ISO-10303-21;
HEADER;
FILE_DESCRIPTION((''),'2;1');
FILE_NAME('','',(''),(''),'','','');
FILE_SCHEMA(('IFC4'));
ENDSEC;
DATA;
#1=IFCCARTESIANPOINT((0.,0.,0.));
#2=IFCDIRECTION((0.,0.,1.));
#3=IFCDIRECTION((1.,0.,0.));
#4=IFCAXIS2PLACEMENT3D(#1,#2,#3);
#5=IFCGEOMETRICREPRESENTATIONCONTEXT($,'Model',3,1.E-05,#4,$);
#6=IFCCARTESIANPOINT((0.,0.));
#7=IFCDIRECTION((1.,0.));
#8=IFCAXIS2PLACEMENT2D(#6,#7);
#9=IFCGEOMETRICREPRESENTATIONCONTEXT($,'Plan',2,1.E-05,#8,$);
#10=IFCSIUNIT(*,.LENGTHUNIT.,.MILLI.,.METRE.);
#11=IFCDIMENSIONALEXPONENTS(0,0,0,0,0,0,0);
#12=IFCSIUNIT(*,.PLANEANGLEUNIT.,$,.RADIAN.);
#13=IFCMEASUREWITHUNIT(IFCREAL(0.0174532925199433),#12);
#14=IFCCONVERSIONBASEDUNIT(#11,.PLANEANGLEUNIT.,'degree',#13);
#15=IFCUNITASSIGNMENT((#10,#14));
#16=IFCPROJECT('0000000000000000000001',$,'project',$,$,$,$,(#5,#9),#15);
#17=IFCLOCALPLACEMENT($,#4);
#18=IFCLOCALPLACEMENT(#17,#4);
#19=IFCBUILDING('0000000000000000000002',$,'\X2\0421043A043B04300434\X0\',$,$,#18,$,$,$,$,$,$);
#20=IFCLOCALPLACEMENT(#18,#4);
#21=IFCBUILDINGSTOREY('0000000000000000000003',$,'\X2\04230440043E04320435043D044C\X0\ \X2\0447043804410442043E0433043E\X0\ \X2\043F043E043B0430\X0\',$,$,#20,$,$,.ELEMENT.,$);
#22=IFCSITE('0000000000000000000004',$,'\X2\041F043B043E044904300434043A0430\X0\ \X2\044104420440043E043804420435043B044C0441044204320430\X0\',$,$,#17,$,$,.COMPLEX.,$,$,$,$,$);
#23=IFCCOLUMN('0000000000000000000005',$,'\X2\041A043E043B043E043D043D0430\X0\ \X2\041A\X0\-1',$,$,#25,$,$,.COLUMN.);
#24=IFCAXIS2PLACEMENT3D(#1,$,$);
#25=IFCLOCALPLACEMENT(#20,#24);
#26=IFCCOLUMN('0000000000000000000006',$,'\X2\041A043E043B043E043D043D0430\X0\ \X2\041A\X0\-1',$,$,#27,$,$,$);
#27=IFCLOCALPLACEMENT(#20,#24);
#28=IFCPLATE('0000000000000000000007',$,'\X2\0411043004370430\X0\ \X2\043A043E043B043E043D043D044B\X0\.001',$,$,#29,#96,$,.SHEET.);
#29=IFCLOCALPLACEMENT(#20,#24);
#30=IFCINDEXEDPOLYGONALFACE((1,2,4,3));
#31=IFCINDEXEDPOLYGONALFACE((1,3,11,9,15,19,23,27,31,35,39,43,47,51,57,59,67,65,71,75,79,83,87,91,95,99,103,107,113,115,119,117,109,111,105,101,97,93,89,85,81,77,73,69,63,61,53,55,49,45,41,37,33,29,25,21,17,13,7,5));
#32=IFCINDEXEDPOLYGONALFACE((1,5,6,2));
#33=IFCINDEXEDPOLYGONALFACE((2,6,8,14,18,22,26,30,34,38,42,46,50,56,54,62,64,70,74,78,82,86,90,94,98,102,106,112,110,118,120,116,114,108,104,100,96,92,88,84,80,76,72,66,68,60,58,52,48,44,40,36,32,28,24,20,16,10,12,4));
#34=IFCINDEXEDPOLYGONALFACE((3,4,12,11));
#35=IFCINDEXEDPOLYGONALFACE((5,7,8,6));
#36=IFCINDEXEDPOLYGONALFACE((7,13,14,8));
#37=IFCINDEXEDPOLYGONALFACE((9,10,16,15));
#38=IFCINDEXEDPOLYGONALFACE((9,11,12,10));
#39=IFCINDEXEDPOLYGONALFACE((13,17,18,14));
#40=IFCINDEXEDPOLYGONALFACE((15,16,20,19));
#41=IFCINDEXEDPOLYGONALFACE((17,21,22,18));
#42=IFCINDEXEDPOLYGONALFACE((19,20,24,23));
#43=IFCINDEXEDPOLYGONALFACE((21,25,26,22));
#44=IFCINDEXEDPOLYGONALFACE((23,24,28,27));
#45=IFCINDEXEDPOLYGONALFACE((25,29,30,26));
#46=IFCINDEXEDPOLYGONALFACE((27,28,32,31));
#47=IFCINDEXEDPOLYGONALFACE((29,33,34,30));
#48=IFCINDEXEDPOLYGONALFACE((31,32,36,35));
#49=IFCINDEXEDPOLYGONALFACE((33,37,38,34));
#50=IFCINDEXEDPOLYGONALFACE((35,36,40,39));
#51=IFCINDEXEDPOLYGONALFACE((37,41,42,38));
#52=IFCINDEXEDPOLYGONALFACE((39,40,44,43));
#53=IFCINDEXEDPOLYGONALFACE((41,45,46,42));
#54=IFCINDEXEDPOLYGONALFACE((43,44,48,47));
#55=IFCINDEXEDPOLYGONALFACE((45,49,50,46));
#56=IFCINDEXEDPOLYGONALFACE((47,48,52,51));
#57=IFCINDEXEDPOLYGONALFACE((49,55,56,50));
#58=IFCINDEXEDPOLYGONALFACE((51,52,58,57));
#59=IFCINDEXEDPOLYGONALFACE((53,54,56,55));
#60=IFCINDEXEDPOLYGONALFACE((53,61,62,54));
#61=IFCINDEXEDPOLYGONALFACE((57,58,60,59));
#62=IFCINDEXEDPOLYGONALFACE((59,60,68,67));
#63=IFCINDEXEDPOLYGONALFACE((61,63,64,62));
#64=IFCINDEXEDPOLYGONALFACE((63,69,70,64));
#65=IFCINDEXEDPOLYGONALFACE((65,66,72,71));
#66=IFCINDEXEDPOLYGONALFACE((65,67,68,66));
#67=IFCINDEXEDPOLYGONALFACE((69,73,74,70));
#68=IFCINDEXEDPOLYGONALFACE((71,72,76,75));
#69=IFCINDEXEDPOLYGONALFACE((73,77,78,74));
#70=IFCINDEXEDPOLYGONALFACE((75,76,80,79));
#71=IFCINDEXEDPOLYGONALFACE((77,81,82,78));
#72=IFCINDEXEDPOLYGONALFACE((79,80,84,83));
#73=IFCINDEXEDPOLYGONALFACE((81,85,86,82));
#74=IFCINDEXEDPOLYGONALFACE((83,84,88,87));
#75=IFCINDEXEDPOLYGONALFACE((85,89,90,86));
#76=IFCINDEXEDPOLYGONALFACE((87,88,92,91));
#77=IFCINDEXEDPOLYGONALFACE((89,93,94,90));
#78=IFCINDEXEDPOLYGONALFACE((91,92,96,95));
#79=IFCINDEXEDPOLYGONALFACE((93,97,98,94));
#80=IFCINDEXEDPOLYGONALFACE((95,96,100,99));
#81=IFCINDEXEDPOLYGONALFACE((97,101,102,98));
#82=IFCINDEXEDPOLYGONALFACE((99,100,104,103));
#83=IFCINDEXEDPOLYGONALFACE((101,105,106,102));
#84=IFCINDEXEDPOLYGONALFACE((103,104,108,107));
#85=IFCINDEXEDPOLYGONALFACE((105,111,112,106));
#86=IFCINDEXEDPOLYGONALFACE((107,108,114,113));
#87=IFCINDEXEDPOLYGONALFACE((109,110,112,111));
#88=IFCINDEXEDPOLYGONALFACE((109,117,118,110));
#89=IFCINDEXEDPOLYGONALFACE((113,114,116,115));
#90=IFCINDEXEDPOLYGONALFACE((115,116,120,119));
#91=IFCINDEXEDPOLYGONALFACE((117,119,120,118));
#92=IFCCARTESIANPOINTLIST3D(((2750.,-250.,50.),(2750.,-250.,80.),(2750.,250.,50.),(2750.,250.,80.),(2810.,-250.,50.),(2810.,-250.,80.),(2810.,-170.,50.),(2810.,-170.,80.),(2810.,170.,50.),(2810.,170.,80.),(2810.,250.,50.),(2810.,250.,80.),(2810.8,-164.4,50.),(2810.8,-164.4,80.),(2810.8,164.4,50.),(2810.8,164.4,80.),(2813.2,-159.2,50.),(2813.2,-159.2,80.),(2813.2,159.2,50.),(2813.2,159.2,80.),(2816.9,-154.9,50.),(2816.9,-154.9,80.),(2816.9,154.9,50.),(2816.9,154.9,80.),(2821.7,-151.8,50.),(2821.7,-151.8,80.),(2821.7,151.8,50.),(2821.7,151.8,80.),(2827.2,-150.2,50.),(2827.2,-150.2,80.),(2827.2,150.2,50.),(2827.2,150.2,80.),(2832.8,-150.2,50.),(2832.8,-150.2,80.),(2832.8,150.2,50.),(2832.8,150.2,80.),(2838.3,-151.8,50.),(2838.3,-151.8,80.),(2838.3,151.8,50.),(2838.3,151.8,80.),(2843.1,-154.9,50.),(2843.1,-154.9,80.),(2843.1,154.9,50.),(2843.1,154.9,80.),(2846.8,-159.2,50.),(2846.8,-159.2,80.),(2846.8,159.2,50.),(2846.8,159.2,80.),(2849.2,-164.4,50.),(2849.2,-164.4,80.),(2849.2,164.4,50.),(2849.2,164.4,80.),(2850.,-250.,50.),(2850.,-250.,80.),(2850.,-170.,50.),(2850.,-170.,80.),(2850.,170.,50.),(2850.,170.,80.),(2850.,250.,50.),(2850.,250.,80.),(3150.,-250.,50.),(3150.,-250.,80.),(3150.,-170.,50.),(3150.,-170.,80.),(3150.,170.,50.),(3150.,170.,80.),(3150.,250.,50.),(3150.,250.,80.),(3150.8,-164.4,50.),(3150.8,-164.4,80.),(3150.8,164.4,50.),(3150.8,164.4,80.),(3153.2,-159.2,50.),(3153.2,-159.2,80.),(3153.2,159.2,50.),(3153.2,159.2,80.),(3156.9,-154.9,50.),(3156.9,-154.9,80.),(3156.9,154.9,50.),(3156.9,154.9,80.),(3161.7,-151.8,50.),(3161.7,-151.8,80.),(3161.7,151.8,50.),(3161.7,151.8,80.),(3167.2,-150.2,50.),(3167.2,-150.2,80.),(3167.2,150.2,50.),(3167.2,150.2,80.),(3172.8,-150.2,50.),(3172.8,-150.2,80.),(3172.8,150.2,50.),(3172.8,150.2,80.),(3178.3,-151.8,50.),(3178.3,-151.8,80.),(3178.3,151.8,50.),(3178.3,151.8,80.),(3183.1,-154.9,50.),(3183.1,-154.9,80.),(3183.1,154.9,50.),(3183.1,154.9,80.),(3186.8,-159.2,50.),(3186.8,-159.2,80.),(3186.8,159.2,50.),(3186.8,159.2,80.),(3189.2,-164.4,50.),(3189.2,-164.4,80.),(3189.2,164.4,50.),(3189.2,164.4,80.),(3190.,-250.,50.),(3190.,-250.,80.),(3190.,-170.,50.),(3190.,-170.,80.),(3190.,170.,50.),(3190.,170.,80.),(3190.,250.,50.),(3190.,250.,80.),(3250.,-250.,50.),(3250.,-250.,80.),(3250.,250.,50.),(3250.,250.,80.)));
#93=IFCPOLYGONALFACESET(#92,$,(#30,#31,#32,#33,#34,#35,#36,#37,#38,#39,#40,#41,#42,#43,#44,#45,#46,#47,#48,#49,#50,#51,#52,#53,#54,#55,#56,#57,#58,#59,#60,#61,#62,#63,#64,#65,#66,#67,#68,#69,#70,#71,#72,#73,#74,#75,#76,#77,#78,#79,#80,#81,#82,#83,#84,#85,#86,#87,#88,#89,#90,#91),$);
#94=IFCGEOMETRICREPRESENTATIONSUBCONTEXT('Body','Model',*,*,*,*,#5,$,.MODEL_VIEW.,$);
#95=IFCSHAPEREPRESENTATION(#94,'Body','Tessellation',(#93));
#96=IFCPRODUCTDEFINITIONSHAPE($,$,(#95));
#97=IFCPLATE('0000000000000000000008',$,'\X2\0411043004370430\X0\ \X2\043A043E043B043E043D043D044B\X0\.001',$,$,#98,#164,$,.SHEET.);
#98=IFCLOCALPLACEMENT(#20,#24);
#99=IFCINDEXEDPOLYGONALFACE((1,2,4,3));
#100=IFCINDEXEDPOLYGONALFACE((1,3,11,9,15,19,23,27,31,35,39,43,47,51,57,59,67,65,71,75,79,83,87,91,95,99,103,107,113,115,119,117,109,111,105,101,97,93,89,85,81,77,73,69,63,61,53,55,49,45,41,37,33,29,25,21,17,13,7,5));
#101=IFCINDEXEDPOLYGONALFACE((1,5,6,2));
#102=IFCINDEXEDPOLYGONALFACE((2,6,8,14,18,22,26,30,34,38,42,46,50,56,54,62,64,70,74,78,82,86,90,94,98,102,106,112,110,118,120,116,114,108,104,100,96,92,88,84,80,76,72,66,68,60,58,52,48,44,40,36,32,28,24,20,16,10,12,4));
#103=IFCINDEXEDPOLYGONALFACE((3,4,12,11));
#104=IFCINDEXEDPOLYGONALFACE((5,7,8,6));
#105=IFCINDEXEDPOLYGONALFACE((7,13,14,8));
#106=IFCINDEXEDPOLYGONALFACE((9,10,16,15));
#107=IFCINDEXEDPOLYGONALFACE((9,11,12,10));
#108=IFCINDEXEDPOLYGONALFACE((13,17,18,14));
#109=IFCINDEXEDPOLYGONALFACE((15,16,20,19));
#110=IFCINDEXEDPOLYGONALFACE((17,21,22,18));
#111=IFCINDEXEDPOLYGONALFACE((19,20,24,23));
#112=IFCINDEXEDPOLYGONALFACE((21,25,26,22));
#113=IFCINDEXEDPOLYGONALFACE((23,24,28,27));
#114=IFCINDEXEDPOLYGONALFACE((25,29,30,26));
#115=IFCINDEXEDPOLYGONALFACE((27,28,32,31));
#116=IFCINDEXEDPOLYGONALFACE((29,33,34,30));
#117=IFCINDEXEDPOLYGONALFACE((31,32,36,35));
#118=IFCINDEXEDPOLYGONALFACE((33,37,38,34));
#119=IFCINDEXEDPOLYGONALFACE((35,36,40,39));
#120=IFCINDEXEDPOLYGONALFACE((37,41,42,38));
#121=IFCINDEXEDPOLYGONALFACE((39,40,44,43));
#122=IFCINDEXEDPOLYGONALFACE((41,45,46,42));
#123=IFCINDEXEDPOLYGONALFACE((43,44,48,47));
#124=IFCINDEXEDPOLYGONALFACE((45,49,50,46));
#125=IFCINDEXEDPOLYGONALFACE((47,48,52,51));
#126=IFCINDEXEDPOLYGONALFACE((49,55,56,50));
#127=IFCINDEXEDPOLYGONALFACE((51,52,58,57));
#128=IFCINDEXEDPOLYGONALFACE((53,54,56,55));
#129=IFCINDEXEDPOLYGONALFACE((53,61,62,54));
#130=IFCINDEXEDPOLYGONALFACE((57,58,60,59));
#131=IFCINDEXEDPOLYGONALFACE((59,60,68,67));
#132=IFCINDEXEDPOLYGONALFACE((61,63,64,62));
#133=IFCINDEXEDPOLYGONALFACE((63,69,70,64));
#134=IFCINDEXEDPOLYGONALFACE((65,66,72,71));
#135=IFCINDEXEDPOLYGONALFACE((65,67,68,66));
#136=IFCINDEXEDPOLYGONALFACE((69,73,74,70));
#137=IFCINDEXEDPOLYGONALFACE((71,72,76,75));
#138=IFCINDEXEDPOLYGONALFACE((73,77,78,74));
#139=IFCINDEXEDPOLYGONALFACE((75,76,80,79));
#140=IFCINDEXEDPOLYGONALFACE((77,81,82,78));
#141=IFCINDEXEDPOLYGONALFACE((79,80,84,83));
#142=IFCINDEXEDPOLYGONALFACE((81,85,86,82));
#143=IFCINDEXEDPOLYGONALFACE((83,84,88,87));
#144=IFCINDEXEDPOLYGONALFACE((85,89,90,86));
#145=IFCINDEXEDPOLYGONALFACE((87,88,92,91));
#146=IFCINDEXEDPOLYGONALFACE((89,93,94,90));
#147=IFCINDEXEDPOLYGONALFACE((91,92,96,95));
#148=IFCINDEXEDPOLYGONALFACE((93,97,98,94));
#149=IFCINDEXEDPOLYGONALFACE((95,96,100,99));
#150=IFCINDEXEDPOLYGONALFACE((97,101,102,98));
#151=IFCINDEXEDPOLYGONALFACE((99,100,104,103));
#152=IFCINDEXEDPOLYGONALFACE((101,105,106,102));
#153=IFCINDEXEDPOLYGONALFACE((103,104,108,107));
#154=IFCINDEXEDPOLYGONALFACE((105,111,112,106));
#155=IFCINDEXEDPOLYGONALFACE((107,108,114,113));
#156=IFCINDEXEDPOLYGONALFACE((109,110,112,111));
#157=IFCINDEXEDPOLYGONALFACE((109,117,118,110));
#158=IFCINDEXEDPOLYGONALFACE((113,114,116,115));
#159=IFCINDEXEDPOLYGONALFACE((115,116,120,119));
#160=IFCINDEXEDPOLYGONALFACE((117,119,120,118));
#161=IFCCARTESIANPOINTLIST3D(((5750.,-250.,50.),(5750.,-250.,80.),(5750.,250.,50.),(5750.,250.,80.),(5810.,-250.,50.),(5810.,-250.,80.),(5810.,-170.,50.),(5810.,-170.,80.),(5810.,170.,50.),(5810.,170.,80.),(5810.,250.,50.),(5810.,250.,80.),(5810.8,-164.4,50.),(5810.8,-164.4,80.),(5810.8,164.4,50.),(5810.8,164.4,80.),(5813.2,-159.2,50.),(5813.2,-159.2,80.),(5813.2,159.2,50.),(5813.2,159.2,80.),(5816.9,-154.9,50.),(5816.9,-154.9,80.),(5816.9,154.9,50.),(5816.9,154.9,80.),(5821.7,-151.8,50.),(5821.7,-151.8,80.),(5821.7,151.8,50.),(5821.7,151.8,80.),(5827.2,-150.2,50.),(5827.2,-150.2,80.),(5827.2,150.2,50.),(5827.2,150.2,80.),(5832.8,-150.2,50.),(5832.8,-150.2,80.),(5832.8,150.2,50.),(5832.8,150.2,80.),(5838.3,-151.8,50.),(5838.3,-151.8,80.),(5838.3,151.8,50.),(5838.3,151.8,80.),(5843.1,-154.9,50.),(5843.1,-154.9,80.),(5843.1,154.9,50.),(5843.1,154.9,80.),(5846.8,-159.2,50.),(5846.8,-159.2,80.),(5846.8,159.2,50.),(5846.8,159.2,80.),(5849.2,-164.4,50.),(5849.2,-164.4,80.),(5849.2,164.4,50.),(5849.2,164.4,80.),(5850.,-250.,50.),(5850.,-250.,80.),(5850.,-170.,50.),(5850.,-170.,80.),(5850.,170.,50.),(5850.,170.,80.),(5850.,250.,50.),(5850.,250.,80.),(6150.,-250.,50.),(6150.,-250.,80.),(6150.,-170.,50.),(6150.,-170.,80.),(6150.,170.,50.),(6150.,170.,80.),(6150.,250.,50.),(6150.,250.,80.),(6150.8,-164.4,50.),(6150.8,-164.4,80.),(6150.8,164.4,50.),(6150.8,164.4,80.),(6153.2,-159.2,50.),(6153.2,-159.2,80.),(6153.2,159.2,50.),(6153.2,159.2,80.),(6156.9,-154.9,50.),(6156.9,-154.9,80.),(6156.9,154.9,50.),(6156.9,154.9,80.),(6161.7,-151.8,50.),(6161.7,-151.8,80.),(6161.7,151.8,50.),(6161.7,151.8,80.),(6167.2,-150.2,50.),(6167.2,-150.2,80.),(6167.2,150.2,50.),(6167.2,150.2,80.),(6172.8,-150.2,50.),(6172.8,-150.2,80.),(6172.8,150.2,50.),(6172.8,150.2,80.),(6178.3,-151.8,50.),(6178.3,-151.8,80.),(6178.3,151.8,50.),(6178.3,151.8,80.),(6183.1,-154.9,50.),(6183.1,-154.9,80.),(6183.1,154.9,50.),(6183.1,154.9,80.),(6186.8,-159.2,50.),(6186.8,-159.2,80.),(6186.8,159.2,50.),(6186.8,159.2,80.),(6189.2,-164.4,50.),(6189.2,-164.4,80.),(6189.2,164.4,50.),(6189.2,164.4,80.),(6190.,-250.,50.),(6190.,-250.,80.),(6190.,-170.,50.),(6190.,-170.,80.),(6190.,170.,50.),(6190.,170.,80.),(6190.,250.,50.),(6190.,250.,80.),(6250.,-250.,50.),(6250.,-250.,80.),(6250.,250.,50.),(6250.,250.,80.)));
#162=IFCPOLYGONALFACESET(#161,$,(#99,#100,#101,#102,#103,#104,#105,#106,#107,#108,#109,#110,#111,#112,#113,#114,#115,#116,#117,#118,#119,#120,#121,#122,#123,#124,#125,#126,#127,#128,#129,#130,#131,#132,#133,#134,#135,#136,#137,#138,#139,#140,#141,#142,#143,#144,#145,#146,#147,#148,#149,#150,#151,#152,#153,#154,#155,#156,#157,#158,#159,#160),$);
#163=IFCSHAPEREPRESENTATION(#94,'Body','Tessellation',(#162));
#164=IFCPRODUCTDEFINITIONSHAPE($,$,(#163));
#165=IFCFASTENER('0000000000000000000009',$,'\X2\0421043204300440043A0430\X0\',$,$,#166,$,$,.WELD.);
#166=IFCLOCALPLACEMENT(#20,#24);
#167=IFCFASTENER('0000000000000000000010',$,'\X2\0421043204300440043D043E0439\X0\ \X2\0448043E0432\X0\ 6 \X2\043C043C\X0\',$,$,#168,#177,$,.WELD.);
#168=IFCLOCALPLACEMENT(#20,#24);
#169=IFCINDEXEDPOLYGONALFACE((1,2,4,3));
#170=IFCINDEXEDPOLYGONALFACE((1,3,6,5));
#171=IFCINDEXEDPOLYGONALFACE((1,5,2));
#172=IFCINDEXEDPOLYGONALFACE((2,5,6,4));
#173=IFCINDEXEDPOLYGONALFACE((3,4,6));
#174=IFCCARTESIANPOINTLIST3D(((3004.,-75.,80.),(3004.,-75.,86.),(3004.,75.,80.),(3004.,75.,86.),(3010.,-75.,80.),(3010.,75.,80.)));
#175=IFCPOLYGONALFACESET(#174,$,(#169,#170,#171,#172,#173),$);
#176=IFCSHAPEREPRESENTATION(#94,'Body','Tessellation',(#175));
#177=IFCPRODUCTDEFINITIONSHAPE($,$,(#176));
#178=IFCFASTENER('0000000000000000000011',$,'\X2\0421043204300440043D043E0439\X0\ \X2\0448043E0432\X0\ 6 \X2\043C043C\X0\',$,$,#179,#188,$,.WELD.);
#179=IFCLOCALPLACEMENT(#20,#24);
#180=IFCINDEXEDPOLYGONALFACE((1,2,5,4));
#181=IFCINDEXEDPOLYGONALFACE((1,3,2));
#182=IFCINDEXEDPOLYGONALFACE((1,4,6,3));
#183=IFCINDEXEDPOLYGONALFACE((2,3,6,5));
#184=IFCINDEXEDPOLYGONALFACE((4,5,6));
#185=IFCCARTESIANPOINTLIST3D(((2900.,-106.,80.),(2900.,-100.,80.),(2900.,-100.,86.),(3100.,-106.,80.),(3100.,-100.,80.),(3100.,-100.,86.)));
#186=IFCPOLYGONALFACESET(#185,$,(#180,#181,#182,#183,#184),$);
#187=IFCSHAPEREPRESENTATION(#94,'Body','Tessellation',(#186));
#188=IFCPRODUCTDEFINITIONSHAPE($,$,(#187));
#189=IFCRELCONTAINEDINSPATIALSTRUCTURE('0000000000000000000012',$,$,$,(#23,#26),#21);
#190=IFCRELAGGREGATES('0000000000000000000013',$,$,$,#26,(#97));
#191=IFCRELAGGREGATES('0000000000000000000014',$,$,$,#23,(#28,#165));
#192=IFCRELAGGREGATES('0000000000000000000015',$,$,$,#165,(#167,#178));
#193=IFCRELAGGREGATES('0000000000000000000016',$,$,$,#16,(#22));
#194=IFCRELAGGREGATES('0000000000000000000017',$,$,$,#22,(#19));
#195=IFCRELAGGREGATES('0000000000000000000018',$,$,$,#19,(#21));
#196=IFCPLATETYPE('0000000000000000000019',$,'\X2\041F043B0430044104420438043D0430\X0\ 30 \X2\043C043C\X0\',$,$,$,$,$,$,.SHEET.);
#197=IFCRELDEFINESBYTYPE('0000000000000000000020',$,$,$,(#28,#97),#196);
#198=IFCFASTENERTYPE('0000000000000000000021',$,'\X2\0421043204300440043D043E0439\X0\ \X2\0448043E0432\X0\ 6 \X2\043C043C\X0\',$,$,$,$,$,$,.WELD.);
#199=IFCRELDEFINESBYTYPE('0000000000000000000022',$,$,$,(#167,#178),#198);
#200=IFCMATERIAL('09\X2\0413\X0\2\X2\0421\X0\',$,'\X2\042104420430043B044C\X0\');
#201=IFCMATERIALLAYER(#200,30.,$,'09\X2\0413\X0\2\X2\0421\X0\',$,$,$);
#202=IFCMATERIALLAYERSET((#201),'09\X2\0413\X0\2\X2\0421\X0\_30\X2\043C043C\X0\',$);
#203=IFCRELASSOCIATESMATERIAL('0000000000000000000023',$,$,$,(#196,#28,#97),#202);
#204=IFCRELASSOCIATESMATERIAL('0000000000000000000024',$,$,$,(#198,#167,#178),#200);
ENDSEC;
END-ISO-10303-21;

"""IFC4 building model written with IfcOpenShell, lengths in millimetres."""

from ifc_helpers import new_model, entity, si_unit, converted_unit, frame, origin_with_axes, origin_2d_with_axis, place, context, subcontext, project, spatial, line, arc, indexed_curve, outline, extrude, material, layer, layer_set, layer_usage, material_profile, profile_set, profile_usage, type_object, element, aggregate, save


model = new_model("IFC4")

# Units and contexts
model_context = context("Model", 3, precision=1e-05, world=origin_with_axes())
plan_context = context("Plan", 2, precision=1e-05, world=origin_2d_with_axis())
body_context = subcontext(model_context, "Body", "Model", "MODEL_VIEW")
ifc_project = project(units=[si_unit("LENGTHUNIT", "METRE", prefix="MILLI"), converted_unit("PLANEANGLEUNIT", "degree", entity("IfcReal", 0.0174532925199433), si_unit("PLANEANGLEUNIT", "RADIAN"), dimensions=[0, 0, 0, 0, 0, 0, 0])], contexts=[model_context, plan_context])

# Site, building, storey
site_placement = place(None, origin_with_axes())
site = spatial("IfcSite", under=ifc_project, at=site_placement, Name="Площадка строительства", CompositionType="COMPLEX")
building_placement = place(site_placement, origin_with_axes())
building = spatial("IfcBuilding", under=site, at=building_placement, Name="Склад")
storey_placement = place(building_placement, origin_with_axes())
storey = spatial("IfcBuildingStorey", under=building, at=storey_placement, Name="Уровень чистого пола", CompositionType="ELEMENT")

# Column
placement = place(storey_placement, origin_with_axes())
column_1 = element("IfcColumn", 1, at=placement, inside=storey, Name="Колонна К-1", PredefinedType="COLUMN")

# Column
column_2 = element("IfcColumn", 2, at=placement, inside=storey, Name="Колонна К-1")

# Shared definitions
ifc_material_1 = material(Name="09Г2С", Category="Сталь")

# Plates
ifc_layer = layer(ifc_material_1, 30.0, Name="09Г2С")
ifc_layer_set = layer_set([ifc_layer], Name="09Г2С_30мм")
ifc_layer_usage = layer_usage(ifc_layer_set, "AXIS3", "POSITIVE", 0.0)
plate_type = type_object("IfcPlateType", Name="Пластина 30 мм", PredefinedType="SHEET", material=ifc_layer_set)
plate_1_placement = place(placement, frame((3000.0, 0.0, 50.0), z_axis=(0.0, 0.0, 1.0), x_axis=(1.0, 0.0, 0.0)))
plate_1 = element("IfcPlate", 3, at=plate_1_placement, type_object=plate_type, material=ifc_layer_usage, Name="База колонны.001", PredefinedType="SHEET", context=body_context, shape_type="SweptSolid", body=[
    extrude(outline(indexed_curve([(190.0, 250.0), (250.0, 250.0), (250.0, -250.0), (190.0, -250.0), (190.0, -170.0), (170.0, -150.0), (150.0, -170.0), (150.0, -250.0), (-150.0, -250.0), (-150.0, -170.0), (-170.0, -150.0), (-190.0, -170.0), (-190.0, -250.0), (-250.0, -250.0), (-250.0, 250.0), (-190.0, 250.0), (-190.0, 170.0), (-170.0, 150.0), (-150.0, 170.0), (-150.0, 250.0), (150.0, 250.0), (150.0, 170.0), (170.0, 150.0), (190.0, 170.0)], segments=[line(21, 20), line(20, 19), arc(19, 18, 17), line(17, 16), line(16, 15), line(15, 14), line(14, 13), line(13, 12), arc(12, 11, 10), line(10, 9), line(9, 8), line(8, 7), arc(7, 6, 5), line(5, 4), line(4, 3), line(3, 2), line(2, 1), line(1, 24), arc(24, 23, 22), line(22, 21)], self_intersect=False)), None, (0.0, 0.0, 1.0), 30.0),
])
plate_2_placement = place(placement, frame((6000.0, 0.0, 50.0), z_axis=(0.0, 0.0, 1.0), x_axis=(1.0, 0.0, 0.0)))
plate_2 = element("IfcPlate", 4, at=plate_2_placement, type_object=plate_type, material=ifc_layer_usage, Name="База колонны.001", PredefinedType="SHEET", context=body_context, shape_type="SweptSolid", body=[
    extrude(outline(indexed_curve([(190.0, 250.0), (250.0, 250.0), (250.0, -250.0), (190.0, -250.0), (190.0, -170.0), (170.0, -150.0), (150.0, -170.0), (150.0, -250.0), (-150.0, -250.0), (-150.0, -170.0), (-170.0, -150.0), (-190.0, -170.0), (-190.0, -250.0), (-250.0, -250.0), (-250.0, 250.0), (-190.0, 250.0), (-190.0, 170.0), (-170.0, 150.0), (-150.0, 170.0), (-150.0, 250.0), (150.0, 250.0), (150.0, 170.0), (170.0, 150.0), (190.0, 170.0)], segments=[line(21, 20), line(20, 19), arc(19, 18, 17), line(17, 16), line(16, 15), line(15, 14), line(14, 13), line(13, 12), arc(12, 11, 10), line(10, 9), line(9, 8), line(8, 7), arc(7, 6, 5), line(5, 4), line(4, 3), line(3, 2), line(2, 1), line(1, 24), arc(24, 23, 22), line(22, 21)], self_intersect=False)), None, (0.0, 0.0, 1.0), 30.0),
])
aggregate(column_2, [plate_2])

# Fasteners
fastener_1_placement = place(placement, frame((3000.0, 0.0, 0.0), z_axis=(0.0, 0.0, 1.0), x_axis=(1.0, 0.0, 0.0)))
fastener_1 = element("IfcFastener", 5, at=fastener_1_placement, Name="Сварка", PredefinedType="WELD")
aggregate(column_1, [plate_1, fastener_1])
ifc_material_profile_1 = material_profile(ifc_material_1, outline(indexed_curve([(0.0, 0.0), (6.0, 0.0), (0.0, 6.0)], segments=[line(2, 3), line(3, 1), line(1, 2)], self_intersect=False)))
ifc_profile_set_1 = profile_set([ifc_material_profile_1])
ifc_profile_usage_1 = profile_usage(ifc_profile_set_1, cardinal=5)
fastener_type = type_object("IfcFastenerType", Name="Сварной шов 6 мм", PredefinedType="WELD", material=ifc_profile_set_1)
fastener_2_placement = place(fastener_1_placement, frame((4.0, 75.0, 80.0), z_axis=(0.0, -1.0, 0.0), x_axis=(1.0, 0.0, 0.0)))
fastener_2 = element("IfcFastener", 6, at=fastener_2_placement, type_object=fastener_type, material=ifc_profile_usage_1, Name="Сварной шов 6 мм", PredefinedType="WELD", context=body_context, shape_type="SweptSolid", body=[
    extrude(outline(indexed_curve([(0.0, 0.0), (6.0, 0.0), (0.0, 6.0)], segments=[line(2, 3), line(3, 1), line(1, 2)], self_intersect=False)), origin_with_axes(), (0.0, 0.0, 1.0), 150.0),
])
fastener_3_placement = place(fastener_1_placement, frame((100.0, -100.0, 80.0), z_axis=(-1.0, 0.0, 0.0), x_axis=(0.0, -1.0, 0.0)))
fastener_3 = element("IfcFastener", 7, at=fastener_3_placement, type_object=fastener_type, material=ifc_profile_usage_1, Name="Сварной шов 6 мм", PredefinedType="WELD", context=body_context, shape_type="SweptSolid", body=[
    extrude(outline(indexed_curve([(0.0, 0.0), (6.0, 0.0), (0.0, 6.0)], segments=[line(2, 3), line(3, 1), line(1, 2)], self_intersect=False)), origin_with_axes(), (0.0, 0.0, 1.0), 200.0),
])
aggregate(fastener_1, [fastener_2, fastener_3])

save(model, "model.ifc")
